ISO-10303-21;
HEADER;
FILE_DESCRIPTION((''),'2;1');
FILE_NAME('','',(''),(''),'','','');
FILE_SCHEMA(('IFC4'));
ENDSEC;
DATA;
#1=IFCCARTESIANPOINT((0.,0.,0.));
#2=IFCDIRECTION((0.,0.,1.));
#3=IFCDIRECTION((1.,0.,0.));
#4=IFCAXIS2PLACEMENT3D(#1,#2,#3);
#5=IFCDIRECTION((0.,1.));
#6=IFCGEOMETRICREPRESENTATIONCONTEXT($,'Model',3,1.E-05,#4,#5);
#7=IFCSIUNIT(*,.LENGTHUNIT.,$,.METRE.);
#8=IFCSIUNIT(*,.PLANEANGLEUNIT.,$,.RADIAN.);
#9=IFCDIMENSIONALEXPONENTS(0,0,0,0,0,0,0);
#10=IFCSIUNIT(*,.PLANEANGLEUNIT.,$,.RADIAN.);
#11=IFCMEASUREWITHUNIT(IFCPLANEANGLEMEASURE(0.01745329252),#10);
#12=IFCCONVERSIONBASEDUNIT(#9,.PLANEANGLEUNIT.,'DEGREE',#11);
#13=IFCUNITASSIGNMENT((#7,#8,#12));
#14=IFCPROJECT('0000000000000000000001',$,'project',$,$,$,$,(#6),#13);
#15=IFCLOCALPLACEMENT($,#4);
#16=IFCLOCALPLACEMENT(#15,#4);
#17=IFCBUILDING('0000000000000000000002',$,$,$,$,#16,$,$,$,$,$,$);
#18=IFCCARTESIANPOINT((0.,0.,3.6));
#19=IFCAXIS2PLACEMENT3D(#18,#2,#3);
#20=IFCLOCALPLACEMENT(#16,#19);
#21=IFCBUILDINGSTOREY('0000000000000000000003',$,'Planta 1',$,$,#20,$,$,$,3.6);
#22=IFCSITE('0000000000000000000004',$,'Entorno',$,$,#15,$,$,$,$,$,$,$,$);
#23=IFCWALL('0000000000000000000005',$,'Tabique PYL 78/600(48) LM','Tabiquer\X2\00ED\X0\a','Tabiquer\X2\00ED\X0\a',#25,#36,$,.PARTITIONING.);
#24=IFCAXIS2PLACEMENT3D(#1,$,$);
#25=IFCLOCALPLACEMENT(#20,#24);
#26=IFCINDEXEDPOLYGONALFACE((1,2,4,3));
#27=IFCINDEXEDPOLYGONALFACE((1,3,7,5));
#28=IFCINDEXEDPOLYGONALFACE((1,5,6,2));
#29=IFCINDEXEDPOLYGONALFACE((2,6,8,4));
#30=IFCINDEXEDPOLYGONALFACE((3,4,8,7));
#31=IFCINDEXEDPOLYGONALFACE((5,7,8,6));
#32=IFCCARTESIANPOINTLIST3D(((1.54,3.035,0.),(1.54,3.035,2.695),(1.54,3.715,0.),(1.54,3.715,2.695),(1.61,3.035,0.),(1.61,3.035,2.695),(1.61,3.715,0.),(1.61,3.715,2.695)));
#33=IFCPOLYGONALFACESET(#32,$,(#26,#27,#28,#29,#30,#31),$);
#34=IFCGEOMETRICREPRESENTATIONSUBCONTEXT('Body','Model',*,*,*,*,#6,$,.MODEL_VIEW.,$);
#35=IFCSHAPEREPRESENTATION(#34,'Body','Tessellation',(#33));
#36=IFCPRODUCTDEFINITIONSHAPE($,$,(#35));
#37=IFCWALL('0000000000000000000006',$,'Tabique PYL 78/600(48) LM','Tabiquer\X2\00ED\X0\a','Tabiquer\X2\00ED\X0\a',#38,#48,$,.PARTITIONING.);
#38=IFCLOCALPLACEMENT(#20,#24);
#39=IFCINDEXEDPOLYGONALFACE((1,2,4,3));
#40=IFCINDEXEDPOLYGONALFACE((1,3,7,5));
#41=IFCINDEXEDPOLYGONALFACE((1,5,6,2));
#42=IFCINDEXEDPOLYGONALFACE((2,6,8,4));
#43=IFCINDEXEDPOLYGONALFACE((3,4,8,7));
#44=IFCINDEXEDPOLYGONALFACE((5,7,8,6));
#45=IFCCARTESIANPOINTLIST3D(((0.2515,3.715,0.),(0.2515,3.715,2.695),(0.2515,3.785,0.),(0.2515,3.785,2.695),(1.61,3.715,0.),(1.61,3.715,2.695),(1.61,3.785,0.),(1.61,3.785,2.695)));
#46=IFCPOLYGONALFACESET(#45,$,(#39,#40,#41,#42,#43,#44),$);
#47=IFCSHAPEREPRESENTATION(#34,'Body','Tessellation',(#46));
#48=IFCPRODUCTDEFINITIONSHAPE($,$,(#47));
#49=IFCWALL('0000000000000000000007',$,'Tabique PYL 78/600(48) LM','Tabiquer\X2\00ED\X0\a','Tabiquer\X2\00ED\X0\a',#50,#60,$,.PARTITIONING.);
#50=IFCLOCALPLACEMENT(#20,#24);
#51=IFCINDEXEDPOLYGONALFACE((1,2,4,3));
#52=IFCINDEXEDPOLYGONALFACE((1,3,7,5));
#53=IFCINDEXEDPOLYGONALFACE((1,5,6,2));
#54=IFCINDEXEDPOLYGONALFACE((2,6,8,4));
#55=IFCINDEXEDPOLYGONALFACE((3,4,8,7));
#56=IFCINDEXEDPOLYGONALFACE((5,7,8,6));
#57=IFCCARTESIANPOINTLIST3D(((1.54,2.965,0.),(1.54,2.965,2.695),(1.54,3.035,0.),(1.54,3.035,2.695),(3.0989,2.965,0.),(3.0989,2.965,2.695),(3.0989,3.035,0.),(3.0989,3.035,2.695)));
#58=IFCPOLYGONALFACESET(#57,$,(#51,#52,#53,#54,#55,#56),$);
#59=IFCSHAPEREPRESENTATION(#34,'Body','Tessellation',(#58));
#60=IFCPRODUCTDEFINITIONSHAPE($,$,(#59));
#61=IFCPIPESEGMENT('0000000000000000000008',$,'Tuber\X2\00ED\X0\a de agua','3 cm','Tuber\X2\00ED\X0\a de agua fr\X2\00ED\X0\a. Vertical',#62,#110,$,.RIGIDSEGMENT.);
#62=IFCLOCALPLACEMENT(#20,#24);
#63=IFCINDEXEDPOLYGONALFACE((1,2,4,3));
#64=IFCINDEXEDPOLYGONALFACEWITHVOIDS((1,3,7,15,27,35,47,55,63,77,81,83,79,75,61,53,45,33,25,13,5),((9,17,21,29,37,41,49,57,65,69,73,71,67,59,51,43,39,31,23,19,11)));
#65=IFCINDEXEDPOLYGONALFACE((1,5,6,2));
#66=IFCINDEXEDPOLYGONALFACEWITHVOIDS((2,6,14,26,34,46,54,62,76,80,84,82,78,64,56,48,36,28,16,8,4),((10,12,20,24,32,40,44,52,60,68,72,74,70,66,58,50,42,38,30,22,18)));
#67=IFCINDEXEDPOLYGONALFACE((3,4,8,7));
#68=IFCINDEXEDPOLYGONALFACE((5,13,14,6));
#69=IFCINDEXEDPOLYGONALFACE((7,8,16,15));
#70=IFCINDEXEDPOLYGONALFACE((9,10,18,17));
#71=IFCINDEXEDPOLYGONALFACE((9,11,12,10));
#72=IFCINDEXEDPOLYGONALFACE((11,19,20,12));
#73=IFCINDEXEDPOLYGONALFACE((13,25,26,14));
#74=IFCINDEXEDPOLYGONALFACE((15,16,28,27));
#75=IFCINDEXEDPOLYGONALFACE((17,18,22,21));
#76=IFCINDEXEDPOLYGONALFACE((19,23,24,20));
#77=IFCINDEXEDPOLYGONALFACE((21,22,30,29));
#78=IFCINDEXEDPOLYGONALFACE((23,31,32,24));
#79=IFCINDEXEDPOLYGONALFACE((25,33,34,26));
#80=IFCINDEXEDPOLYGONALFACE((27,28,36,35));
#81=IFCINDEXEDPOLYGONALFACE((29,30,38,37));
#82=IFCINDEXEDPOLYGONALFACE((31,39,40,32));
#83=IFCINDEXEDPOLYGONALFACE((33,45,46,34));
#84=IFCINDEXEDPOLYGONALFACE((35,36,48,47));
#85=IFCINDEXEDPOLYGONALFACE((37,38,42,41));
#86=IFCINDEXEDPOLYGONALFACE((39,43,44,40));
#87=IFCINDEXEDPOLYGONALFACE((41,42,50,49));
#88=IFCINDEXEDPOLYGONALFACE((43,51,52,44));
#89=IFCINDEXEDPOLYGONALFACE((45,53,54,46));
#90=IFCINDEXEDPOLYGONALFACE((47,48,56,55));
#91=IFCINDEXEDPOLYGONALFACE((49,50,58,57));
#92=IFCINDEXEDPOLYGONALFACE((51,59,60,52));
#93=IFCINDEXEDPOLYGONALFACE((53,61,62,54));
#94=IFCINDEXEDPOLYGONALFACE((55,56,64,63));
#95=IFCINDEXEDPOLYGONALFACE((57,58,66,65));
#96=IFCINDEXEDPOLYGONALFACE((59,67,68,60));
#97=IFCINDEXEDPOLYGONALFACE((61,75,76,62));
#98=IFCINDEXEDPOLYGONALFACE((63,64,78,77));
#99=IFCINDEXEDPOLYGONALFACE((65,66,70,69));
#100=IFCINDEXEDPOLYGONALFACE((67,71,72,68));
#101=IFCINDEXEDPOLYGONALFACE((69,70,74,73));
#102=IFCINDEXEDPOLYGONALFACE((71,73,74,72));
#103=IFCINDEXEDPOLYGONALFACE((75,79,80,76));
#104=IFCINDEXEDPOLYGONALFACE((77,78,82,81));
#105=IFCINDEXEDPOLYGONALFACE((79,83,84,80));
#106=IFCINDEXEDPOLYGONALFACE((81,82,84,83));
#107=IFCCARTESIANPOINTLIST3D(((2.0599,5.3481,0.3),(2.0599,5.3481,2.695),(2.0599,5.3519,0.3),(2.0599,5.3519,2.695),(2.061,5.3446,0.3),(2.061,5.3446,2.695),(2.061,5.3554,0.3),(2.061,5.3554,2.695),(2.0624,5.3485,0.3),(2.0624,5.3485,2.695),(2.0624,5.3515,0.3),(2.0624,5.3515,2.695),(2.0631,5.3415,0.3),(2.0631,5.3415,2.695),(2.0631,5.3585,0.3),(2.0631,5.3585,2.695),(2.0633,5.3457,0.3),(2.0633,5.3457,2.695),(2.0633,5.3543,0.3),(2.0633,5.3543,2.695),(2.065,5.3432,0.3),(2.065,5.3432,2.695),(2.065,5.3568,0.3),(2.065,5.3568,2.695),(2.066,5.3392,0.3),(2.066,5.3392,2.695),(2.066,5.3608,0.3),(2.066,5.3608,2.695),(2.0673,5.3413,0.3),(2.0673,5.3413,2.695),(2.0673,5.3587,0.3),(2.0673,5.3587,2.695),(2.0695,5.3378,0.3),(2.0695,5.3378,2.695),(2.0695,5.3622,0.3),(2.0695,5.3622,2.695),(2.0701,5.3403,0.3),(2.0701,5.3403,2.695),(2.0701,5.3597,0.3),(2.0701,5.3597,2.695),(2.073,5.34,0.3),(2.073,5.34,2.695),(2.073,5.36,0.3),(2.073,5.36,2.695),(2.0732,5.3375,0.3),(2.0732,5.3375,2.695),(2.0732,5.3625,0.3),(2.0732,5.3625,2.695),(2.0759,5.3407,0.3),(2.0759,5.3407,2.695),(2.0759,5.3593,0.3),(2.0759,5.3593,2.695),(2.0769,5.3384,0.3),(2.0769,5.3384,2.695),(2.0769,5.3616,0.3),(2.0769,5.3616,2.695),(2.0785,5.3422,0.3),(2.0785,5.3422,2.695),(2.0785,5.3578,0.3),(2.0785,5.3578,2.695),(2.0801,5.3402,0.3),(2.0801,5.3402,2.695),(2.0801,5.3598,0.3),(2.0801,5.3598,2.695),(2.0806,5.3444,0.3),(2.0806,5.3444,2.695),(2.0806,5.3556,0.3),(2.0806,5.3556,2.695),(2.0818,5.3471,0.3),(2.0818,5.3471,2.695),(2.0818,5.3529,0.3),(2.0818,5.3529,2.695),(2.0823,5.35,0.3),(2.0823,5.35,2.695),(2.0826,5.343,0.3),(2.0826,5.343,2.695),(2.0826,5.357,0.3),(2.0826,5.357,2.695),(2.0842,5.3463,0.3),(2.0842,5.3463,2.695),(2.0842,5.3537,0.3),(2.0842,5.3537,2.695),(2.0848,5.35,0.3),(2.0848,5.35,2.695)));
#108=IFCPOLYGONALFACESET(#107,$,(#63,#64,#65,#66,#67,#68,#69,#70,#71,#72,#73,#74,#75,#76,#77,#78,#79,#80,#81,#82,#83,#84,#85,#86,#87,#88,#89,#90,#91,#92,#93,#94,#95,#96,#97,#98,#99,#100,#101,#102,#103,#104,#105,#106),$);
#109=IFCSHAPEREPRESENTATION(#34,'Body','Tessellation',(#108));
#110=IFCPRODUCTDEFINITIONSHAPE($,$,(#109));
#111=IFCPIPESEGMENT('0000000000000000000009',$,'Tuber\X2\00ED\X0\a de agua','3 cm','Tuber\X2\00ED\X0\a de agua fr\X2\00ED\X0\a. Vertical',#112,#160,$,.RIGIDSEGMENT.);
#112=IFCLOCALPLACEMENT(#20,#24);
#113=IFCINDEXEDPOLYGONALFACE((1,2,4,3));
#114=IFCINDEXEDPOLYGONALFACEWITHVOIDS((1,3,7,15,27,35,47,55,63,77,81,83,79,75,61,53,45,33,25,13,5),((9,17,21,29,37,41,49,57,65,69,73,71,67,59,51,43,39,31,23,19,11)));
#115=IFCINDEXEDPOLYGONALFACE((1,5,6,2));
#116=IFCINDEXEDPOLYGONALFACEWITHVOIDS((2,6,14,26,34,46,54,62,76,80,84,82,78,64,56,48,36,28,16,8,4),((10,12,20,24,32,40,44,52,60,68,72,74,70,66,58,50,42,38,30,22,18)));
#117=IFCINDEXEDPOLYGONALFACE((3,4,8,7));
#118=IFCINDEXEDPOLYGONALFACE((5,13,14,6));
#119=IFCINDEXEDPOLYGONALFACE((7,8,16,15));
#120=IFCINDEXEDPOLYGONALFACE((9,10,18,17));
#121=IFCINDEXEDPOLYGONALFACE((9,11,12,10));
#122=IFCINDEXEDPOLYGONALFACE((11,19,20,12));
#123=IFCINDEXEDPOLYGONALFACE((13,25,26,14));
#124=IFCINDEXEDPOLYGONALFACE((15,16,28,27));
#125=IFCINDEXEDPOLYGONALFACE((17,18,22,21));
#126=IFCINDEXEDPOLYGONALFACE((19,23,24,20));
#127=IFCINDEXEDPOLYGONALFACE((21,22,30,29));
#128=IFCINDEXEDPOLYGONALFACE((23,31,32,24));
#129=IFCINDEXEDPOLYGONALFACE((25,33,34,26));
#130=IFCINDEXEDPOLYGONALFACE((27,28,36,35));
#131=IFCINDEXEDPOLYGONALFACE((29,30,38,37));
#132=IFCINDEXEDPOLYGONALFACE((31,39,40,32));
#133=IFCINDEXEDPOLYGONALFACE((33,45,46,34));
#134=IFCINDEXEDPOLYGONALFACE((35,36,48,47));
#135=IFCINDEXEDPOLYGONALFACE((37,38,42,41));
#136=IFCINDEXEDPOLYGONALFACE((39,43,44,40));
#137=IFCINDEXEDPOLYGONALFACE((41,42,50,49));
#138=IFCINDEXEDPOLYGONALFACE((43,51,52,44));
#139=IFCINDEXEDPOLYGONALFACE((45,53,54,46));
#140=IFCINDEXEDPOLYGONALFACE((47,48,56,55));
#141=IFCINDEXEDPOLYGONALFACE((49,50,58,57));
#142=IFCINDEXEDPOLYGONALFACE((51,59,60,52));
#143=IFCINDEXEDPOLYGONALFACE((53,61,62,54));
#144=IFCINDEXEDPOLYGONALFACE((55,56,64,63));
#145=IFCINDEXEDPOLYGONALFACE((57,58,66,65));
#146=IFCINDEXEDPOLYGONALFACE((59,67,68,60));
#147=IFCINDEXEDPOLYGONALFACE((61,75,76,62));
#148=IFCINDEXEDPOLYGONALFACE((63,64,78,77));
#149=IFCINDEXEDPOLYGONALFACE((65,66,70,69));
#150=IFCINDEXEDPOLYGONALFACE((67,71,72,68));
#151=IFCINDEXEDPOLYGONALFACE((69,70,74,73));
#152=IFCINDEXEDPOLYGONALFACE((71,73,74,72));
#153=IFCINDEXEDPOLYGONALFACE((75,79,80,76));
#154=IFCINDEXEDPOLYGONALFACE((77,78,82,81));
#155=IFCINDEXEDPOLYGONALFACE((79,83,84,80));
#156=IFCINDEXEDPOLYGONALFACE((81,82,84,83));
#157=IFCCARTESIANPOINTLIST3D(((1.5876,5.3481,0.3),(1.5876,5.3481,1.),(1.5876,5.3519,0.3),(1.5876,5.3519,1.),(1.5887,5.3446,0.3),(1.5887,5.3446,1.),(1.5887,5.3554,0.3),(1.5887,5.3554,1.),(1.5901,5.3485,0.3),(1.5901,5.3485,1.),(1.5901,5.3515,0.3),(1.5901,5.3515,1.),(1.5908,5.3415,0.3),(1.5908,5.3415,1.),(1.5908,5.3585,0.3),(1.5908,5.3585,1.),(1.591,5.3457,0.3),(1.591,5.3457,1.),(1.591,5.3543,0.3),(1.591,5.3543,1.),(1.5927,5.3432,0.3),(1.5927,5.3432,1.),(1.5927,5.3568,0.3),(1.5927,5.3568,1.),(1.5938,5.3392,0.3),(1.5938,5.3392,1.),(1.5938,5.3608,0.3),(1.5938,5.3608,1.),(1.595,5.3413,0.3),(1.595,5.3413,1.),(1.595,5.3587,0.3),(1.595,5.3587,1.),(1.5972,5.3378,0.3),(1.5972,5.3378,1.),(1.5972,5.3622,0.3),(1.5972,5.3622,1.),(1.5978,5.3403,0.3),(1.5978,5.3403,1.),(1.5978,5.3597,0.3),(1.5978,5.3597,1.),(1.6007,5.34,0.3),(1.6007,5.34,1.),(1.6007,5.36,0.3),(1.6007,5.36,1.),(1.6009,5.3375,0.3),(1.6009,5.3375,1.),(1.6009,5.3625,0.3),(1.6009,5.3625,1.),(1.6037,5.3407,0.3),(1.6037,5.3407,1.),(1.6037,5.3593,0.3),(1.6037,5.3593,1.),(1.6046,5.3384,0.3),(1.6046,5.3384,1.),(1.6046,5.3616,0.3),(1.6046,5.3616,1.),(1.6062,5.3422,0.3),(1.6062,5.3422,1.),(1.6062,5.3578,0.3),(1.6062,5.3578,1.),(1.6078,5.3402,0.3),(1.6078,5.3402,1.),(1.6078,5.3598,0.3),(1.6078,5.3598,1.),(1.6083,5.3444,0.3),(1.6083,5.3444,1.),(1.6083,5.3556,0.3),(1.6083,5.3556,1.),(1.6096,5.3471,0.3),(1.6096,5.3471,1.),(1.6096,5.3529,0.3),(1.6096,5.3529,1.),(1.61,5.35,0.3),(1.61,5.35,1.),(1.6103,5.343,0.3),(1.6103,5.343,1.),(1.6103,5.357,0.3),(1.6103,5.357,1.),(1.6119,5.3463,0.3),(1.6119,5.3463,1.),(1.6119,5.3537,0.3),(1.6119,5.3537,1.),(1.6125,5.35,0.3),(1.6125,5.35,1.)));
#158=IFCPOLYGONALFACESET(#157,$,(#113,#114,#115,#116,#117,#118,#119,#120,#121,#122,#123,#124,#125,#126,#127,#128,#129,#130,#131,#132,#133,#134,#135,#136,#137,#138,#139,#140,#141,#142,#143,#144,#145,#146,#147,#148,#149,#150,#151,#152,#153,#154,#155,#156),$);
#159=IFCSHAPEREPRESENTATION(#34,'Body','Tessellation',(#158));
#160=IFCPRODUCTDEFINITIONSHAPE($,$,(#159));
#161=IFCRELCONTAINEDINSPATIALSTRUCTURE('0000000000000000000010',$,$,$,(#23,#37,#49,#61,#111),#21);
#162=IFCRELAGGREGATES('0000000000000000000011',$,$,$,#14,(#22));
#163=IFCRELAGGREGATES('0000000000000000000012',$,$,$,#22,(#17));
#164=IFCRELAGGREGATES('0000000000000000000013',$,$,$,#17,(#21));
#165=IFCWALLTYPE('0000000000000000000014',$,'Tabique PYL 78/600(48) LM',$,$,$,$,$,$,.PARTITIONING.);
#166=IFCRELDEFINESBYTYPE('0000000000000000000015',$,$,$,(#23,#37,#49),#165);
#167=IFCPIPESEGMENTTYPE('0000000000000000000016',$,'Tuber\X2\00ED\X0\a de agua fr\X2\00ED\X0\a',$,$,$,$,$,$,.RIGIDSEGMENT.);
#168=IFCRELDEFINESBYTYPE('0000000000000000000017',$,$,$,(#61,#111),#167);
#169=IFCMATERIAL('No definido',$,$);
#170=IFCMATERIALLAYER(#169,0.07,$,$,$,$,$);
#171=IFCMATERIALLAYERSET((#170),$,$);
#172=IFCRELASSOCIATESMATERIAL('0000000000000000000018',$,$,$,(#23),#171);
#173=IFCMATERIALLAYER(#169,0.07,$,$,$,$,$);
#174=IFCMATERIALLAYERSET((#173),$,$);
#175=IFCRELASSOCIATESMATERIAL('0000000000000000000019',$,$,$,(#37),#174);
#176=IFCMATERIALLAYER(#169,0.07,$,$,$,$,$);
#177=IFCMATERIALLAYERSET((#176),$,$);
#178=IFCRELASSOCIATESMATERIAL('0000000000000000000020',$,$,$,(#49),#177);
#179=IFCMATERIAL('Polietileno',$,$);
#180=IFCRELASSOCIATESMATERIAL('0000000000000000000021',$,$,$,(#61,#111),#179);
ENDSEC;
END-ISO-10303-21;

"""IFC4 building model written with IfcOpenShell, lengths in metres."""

from ifc_helpers import new_model, entity, si_unit, converted_unit, direction, frame, origin_with_axes, origin_2d_with_axis, place, context, subcontext, project, spatial, hollow_circle, extrude, material, layer, layer_set, layer_usage, type_object, element, save


model = new_model("IFC4")

# Units and contexts
model_context = context("Model", 3, precision=1e-05, world=origin_with_axes(), true_north=direction((0.0, 1.0)))
body_context = subcontext(model_context, "Body", "Model", "MODEL_VIEW")
ifc_project = project(units=[si_unit("LENGTHUNIT", "METRE"), si_unit("PLANEANGLEUNIT", "RADIAN"), converted_unit("PLANEANGLEUNIT", "DEGREE", entity("IfcPlaneAngleMeasure", 0.01745329252), si_unit("PLANEANGLEUNIT", "RADIAN"), dimensions=[0, 0, 0, 0, 0, 0, 0])], contexts=[model_context])

# Site, building, storey
site_placement = place(None, origin_with_axes())
site = spatial("IfcSite", under=ifc_project, at=site_placement, Name="Entorno")
building_placement = place(site_placement, origin_with_axes())
building = spatial("IfcBuilding", under=site, at=building_placement)
storey_placement = place(building_placement, frame((0.0, 0.0, 3.6), z_axis=(0.0, 0.0, 1.0), x_axis=(1.0, 0.0, 0.0)))
storey = spatial("IfcBuildingStorey", under=building, at=storey_placement, Name="Planta 1", Elevation=3.6)

# Walls
ifc_material_1 = material(Name="No definido")
ifc_layer_1 = layer(ifc_material_1, 0.07)
ifc_layer_set_1 = layer_set([ifc_layer_1])
ifc_layer_usage_1 = layer_usage(ifc_layer_set_1, "AXIS2", "POSITIVE", -0.035)
wall_type = type_object("IfcWallType", Name="Tabique PYL 78/600(48) LM", PredefinedType="PARTITIONING")
wall_1_placement = place(storey_placement, frame((1.575, 3.75, 0.0), z_axis=(0.0, 0.0, 1.0), x_axis=(0.0, -1.0, 0.0)))
cartesian_point_1 = entity("IfcCartesianPoint", [-0.34, -1.3475])
cartesian_point_2 = entity("IfcCartesianPoint", [-0.34, -1.3475])
element("IfcWall", 1, at=wall_1_placement, inside=storey, type_object=wall_type, material=ifc_layer_usage_1, Name="Tabique PYL 78/600(48) LM", Description="Tabiquería", ObjectType="Tabiquería", PredefinedType="PARTITIONING", context=body_context, shape_type="SolidModel", body=[
    entity("IfcExtrudedAreaSolidTapered", entity("IfcArbitraryClosedProfileDef", "AREA", None, entity("IfcPolyline", [cartesian_point_1, entity("IfcCartesianPoint", [0.34, -1.3475]), entity("IfcCartesianPoint", [0.34, 1.3475]), entity("IfcCartesianPoint", [-0.34, 1.3475]), cartesian_point_1])), entity("IfcAxis2Placement3D", entity("IfcCartesianPoint", [0.375, 0.035, 1.3475]), entity("IfcDirection", [0.0, -1.0, 0.0]), entity("IfcDirection", [1.0, 0.0, 0.0])), entity("IfcDirection", [0.0, 0.0, 1.0]), 0.07, entity("IfcArbitraryClosedProfileDef", "AREA", None, entity("IfcPolyline", [cartesian_point_2, entity("IfcCartesianPoint", [0.34, -1.3475]), entity("IfcCartesianPoint", [0.34, 1.3475]), entity("IfcCartesianPoint", [-0.34, 1.3475]), cartesian_point_2]))),
])
ifc_layer_2 = layer(ifc_material_1, 0.07)
ifc_layer_set_2 = layer_set([ifc_layer_2])
ifc_layer_usage_2 = layer_usage(ifc_layer_set_2, "AXIS2", "POSITIVE", -0.035)
wall_2_placement = place(storey_placement, frame((1.575, 3.75, 0.0), z_axis=(0.0, 0.0, 1.0), x_axis=(-1.0, 0.0, 0.0)))
cartesian_point_3 = entity("IfcCartesianPoint", [-0.6793, -1.3475])
cartesian_point_4 = entity("IfcCartesianPoint", [-0.6793, -1.3475])
element("IfcWall", 2, at=wall_2_placement, inside=storey, type_object=wall_type, material=ifc_layer_usage_2, Name="Tabique PYL 78/600(48) LM", Description="Tabiquería", ObjectType="Tabiquería", PredefinedType="PARTITIONING", context=body_context, shape_type="SolidModel", body=[
    entity("IfcExtrudedAreaSolidTapered", entity("IfcArbitraryClosedProfileDef", "AREA", None, entity("IfcPolyline", [cartesian_point_3, entity("IfcCartesianPoint", [0.6793, -1.3475]), entity("IfcCartesianPoint", [0.6793, 1.3475]), entity("IfcCartesianPoint", [-0.6793, 1.3475]), cartesian_point_3])), entity("IfcAxis2Placement3D", entity("IfcCartesianPoint", [0.6442, 0.035, 1.3475]), entity("IfcDirection", [0.0, -1.0, 0.0]), entity("IfcDirection", [1.0, 0.0, 0.0])), entity("IfcDirection", [0.0, 0.0, 1.0]), 0.07, entity("IfcArbitraryClosedProfileDef", "AREA", None, entity("IfcPolyline", [cartesian_point_4, entity("IfcCartesianPoint", [0.6793, -1.3475]), entity("IfcCartesianPoint", [0.6793, 1.3475]), entity("IfcCartesianPoint", [-0.6793, 1.3475]), cartesian_point_4]))),
])
ifc_layer_3 = layer(ifc_material_1, 0.07)
ifc_layer_set_3 = layer_set([ifc_layer_3])
ifc_layer_usage_3 = layer_usage(ifc_layer_set_3, "AXIS2", "POSITIVE", -0.035)
wall_3_placement = place(storey_placement, frame((1.575, 3.0, 0.0), z_axis=(0.0, 0.0, 1.0), x_axis=(1.0, 0.0, 0.0)))
cartesian_point_5 = entity("IfcCartesianPoint", [-0.7794, -1.3475])
cartesian_point_6 = entity("IfcCartesianPoint", [-0.7794, -1.3475])
element("IfcWall", 3, at=wall_3_placement, inside=storey, type_object=wall_type, material=ifc_layer_usage_3, Name="Tabique PYL 78/600(48) LM", Description="Tabiquería", ObjectType="Tabiquería", PredefinedType="PARTITIONING", context=body_context, shape_type="SolidModel", body=[
    entity("IfcExtrudedAreaSolidTapered", entity("IfcArbitraryClosedProfileDef", "AREA", None, entity("IfcPolyline", [cartesian_point_5, entity("IfcCartesianPoint", [0.7794, -1.3475]), entity("IfcCartesianPoint", [0.7794, 1.3475]), entity("IfcCartesianPoint", [-0.7794, 1.3475]), cartesian_point_5])), entity("IfcAxis2Placement3D", entity("IfcCartesianPoint", [0.7445, 0.035, 1.3475]), entity("IfcDirection", [0.0, -1.0, 0.0]), entity("IfcDirection", [1.0, 0.0, 0.0])), entity("IfcDirection", [0.0, 0.0, 1.0]), 0.07, entity("IfcArbitraryClosedProfileDef", "AREA", None, entity("IfcPolyline", [cartesian_point_6, entity("IfcCartesianPoint", [0.7794, -1.3475]), entity("IfcCartesianPoint", [0.7794, 1.3475]), entity("IfcCartesianPoint", [-0.7794, 1.3475]), cartesian_point_6]))),
])

# Pipe segments
ifc_material_2 = material(Name="Polietileno")
pipe_segment_type_1 = type_object("IfcPipeSegmentType", Name="Tubería de agua fría", PredefinedType="RIGIDSEGMENT")
pipe_segment_1_placement = place(storey_placement, frame((2.0723, 5.35, 2.695), z_axis=(0.0, 0.0, -1.0), x_axis=(1.0, 0.0, 0.0)))
element("IfcPipeSegment", 4, at=pipe_segment_1_placement, inside=storey, type_object=pipe_segment_type_1, material=ifc_material_2, Name="Tubería de agua", Description="3 cm", ObjectType="Tubería de agua fría. Vertical", PredefinedType="RIGIDSEGMENT", context=body_context, shape_type="SweptSolid", body=[
    extrude(hollow_circle(Radius=0.0125, WallThickness=0.0025, at=origin_2d_with_axis()), origin_with_axes(), (0.0, 0.0, 1.0), 2.395),
])
pipe_segment_2_placement = place(storey_placement, frame((1.6, 5.35, 1.0), z_axis=(0.0, 0.0, -1.0), x_axis=(1.0, 0.0, 0.0)))
element("IfcPipeSegment", 5, at=pipe_segment_2_placement, inside=storey, type_object=pipe_segment_type_1, material=ifc_material_2, Name="Tubería de agua", Description="3 cm", ObjectType="Tubería de agua fría. Vertical", PredefinedType="RIGIDSEGMENT", context=body_context, shape_type="SweptSolid", body=[
    extrude(hollow_circle(Radius=0.0125, WallThickness=0.0025, at=origin_2d_with_axis()), origin_with_axes(), (0.0, 0.0, 1.0), 0.7),
])

save(model, "model.ifc")
